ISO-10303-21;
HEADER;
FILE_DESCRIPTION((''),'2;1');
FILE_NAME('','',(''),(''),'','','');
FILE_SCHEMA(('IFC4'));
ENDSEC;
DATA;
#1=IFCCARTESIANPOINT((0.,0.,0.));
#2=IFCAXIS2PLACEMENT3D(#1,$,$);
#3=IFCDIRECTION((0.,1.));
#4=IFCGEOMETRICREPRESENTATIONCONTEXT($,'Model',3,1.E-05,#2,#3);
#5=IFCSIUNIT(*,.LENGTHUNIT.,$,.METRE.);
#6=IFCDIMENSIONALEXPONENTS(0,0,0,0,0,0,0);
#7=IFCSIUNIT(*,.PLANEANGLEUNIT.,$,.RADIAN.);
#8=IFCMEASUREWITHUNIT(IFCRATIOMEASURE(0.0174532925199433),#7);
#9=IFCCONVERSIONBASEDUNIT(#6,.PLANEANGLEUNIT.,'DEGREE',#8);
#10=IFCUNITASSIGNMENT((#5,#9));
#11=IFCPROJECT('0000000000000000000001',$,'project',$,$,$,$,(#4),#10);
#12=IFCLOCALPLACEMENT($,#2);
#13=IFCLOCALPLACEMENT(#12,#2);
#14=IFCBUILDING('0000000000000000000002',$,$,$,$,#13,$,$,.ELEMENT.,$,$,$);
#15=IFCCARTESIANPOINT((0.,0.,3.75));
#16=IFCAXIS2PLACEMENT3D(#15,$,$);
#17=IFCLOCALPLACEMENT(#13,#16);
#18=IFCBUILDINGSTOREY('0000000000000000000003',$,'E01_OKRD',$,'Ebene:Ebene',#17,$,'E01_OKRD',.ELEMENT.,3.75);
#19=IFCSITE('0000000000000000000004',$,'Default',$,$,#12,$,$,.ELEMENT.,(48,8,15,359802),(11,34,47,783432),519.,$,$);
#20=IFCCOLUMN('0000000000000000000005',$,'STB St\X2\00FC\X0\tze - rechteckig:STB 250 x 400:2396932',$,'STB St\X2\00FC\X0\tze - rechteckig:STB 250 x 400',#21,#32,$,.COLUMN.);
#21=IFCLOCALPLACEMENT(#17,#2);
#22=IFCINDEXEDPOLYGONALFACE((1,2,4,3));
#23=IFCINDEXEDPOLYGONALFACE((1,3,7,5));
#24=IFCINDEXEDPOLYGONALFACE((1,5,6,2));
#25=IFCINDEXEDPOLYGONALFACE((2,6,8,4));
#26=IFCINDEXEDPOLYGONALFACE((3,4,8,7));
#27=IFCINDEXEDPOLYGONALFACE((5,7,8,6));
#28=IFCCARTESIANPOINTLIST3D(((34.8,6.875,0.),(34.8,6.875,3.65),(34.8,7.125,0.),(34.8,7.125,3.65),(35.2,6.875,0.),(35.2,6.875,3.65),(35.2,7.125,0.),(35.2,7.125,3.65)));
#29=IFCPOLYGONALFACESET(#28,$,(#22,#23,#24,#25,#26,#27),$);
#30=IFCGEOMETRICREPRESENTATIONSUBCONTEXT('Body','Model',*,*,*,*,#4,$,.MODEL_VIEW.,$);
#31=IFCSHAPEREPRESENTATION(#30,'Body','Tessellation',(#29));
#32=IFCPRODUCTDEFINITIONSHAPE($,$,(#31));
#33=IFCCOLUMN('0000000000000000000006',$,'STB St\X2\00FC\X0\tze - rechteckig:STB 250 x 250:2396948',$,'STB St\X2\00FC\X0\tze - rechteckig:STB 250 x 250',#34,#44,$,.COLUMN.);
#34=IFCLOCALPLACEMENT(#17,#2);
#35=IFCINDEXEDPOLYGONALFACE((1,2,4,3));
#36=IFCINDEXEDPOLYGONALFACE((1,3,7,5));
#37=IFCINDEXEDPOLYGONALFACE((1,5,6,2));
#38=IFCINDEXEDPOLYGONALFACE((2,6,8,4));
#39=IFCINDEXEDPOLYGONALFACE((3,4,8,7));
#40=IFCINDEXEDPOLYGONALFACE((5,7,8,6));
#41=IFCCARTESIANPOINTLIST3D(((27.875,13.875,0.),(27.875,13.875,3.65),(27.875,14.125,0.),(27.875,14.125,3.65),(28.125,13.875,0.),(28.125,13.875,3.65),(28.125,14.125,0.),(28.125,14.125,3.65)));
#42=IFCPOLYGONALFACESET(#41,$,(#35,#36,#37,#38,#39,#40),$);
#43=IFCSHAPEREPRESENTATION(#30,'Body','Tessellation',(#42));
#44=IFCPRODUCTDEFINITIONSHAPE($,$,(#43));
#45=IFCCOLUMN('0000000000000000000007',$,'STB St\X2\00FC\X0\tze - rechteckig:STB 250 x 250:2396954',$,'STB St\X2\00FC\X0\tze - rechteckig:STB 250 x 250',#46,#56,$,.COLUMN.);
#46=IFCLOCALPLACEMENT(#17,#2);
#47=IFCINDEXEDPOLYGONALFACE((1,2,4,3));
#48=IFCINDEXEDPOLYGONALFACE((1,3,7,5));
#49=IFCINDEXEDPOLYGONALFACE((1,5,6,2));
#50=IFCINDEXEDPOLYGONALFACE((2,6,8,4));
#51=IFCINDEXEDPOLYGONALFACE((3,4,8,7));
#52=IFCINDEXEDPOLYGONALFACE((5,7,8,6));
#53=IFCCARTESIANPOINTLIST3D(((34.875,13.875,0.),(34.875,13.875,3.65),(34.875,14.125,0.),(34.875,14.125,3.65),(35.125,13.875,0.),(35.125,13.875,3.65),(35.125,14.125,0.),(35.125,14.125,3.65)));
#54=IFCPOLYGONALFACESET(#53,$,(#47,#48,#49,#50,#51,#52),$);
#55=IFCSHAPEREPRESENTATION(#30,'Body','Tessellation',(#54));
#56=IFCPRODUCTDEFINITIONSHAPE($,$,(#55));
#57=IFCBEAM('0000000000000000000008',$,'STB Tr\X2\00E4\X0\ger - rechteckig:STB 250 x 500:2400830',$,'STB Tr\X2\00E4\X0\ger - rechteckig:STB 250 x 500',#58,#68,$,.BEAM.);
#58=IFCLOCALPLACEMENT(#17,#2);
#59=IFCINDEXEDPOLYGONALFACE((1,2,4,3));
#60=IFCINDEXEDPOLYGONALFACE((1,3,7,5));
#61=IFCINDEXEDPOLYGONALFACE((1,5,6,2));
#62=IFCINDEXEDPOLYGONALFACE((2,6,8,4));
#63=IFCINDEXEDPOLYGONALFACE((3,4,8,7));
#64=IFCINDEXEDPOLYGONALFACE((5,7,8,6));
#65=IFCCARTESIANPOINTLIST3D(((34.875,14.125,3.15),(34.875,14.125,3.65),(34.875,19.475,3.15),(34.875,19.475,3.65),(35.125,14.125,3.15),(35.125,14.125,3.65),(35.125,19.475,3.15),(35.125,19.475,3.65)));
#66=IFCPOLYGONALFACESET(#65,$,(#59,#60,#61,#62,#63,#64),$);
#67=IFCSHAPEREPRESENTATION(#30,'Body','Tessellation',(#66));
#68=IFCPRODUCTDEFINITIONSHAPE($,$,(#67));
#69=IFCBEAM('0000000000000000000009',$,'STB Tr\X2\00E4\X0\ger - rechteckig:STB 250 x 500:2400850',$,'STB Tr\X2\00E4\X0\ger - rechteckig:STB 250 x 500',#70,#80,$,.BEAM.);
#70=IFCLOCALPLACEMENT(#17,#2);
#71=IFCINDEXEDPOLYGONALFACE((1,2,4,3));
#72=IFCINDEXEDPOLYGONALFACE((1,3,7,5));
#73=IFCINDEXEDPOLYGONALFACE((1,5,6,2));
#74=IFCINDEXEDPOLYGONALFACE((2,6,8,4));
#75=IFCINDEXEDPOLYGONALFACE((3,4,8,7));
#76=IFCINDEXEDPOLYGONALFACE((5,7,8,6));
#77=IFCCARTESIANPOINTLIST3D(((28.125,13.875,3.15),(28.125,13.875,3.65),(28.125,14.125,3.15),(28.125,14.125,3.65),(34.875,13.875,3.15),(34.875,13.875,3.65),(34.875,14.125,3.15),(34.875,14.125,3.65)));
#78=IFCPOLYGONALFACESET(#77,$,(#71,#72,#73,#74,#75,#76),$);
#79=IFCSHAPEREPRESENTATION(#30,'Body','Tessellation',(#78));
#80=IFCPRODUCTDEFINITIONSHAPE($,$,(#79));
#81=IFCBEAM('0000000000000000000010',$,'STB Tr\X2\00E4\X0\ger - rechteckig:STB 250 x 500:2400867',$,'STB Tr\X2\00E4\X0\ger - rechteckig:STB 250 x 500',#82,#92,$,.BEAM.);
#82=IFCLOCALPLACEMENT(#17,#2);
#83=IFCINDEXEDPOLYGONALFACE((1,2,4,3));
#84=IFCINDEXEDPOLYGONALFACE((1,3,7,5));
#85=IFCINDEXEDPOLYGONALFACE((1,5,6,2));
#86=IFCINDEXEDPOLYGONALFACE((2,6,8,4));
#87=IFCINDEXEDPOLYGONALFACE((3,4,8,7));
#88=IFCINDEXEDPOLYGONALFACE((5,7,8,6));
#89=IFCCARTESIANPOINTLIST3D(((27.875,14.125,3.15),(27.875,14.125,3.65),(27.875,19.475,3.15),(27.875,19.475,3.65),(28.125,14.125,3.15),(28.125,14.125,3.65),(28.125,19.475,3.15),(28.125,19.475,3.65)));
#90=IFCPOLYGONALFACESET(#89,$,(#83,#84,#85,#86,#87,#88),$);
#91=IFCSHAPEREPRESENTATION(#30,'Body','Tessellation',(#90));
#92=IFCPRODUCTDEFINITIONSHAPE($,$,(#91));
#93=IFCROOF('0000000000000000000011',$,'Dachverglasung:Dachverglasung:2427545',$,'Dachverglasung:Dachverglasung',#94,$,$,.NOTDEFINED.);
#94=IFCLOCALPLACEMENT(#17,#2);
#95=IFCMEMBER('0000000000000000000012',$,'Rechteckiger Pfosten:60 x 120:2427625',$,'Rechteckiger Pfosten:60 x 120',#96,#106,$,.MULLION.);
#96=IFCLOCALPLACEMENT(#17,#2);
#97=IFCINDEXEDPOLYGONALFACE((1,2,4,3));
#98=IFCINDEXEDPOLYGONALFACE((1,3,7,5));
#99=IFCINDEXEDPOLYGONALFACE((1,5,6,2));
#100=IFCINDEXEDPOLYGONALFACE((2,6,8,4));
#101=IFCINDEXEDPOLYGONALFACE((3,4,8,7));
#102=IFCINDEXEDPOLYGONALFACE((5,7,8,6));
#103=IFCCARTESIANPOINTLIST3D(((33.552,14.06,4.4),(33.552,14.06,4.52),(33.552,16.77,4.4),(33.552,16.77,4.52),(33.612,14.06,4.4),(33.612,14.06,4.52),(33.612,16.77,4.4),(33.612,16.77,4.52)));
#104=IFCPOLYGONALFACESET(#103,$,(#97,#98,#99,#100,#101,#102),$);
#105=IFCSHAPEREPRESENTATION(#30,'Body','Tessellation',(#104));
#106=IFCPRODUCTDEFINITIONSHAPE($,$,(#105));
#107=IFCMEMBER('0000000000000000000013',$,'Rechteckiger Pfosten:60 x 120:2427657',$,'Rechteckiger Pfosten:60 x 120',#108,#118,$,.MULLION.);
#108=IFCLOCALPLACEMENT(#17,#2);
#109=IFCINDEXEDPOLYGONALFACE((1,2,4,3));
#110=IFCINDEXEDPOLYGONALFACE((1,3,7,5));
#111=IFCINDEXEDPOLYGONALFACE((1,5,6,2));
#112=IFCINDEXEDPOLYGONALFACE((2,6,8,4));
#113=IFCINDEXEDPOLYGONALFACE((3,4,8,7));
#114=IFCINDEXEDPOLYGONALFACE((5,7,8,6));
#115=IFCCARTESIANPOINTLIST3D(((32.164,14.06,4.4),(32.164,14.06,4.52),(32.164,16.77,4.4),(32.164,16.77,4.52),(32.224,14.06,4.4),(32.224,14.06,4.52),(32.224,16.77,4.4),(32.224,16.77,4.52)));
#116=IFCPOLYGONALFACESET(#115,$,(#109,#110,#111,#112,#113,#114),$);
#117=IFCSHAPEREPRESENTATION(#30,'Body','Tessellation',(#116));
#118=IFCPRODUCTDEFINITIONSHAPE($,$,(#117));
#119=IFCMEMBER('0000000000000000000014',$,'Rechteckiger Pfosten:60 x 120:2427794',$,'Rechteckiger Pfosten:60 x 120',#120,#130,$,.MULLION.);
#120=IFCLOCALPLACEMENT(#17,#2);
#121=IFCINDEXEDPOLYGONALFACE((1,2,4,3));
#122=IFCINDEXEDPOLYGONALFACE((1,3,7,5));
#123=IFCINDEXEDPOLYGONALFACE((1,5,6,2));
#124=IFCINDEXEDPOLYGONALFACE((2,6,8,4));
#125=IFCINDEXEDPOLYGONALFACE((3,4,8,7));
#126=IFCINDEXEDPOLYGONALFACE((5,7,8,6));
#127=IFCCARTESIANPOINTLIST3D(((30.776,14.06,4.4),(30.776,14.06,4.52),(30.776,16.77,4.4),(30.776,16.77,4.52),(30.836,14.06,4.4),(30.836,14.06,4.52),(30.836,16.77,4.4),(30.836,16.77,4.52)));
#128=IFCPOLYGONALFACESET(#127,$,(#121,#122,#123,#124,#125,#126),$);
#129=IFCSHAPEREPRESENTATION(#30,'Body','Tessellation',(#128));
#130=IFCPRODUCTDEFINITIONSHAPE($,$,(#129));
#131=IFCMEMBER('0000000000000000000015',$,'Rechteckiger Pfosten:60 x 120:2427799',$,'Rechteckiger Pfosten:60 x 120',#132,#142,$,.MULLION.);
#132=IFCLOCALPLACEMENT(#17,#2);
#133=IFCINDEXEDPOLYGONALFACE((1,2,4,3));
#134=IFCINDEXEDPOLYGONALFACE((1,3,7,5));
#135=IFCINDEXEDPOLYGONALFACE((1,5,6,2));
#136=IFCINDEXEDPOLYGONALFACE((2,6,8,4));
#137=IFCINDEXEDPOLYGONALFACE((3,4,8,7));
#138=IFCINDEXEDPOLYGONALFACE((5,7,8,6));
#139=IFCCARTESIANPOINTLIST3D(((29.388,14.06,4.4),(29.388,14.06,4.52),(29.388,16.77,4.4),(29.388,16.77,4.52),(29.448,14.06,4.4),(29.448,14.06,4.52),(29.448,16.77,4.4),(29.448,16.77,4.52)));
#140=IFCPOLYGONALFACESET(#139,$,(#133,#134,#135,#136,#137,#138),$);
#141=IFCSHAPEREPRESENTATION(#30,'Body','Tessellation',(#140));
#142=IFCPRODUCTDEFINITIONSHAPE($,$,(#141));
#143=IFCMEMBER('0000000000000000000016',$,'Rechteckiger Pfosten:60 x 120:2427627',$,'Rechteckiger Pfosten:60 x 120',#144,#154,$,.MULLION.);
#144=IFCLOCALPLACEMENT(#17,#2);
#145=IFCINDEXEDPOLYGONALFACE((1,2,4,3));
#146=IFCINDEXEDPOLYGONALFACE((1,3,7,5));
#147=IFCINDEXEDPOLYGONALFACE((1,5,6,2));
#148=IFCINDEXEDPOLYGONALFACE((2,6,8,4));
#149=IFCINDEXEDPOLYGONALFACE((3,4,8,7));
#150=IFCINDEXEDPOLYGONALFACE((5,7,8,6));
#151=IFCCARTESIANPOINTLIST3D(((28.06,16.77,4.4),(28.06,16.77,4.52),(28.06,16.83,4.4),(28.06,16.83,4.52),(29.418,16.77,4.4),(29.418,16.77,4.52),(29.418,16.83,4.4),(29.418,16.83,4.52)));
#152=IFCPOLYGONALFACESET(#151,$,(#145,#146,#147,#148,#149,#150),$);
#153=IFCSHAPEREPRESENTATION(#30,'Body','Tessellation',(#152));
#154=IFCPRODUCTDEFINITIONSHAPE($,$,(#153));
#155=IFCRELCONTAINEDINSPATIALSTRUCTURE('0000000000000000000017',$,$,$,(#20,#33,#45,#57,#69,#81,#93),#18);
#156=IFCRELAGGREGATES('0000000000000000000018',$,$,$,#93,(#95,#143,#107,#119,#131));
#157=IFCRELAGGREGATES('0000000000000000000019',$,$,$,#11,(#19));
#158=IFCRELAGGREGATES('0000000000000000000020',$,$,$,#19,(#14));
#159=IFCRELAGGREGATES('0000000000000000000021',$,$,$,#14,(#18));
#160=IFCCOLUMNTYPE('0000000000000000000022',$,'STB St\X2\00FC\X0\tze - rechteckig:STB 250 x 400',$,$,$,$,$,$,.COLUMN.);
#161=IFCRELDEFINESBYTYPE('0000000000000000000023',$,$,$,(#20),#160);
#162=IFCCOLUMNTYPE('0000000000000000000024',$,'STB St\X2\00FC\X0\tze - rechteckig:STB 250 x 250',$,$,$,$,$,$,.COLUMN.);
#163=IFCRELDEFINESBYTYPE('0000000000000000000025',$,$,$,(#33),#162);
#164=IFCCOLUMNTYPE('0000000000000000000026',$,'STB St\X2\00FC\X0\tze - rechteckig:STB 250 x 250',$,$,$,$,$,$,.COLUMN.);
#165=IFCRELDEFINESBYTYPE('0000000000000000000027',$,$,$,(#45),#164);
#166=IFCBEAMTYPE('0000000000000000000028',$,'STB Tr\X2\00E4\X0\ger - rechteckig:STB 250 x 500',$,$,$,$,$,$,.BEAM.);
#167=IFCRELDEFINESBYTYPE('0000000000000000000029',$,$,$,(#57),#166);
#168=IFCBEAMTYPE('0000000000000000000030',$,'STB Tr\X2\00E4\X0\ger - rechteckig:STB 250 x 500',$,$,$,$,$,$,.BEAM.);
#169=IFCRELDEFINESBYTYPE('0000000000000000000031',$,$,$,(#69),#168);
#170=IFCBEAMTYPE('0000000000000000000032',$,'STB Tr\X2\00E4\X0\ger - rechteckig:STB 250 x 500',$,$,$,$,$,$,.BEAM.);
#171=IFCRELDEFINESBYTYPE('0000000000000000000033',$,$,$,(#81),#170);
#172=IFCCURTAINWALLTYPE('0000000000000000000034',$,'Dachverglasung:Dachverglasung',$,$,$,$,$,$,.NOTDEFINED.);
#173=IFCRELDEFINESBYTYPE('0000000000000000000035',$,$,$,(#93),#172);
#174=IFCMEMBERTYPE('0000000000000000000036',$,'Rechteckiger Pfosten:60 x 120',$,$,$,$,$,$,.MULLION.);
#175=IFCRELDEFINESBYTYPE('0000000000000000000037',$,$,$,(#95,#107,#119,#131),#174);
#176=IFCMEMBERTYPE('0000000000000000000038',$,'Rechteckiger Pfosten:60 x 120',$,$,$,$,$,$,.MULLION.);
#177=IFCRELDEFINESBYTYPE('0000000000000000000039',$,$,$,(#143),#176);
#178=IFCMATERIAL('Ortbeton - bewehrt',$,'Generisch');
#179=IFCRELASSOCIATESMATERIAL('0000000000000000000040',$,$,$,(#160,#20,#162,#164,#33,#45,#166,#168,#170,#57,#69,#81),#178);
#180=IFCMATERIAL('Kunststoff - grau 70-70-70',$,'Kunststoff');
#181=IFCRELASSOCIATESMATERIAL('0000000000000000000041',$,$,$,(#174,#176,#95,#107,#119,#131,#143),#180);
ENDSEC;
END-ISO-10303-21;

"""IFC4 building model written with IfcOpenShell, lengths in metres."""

from ifc_helpers import new_model, entity, si_unit, converted_unit, direction, frame, frame_2d, origin, origin_2d_with_axis, place, context, subcontext, project, spatial, rectangle, extrude, source, transform, mapped, material, material_profile, profile_set, profile_usage, type_object, type_shapes, element, aggregate, save


model = new_model("IFC4")

# Units and contexts
model_context = context("Model", 3, precision=1e-05, world=origin(), true_north=direction((0.0, 1.0)))
body_context = subcontext(model_context, "Body", "Model", "MODEL_VIEW")
ifc_project = project(units=[si_unit("LENGTHUNIT", "METRE"), converted_unit("PLANEANGLEUNIT", "DEGREE", entity("IfcRatioMeasure", 0.0174532925199433), si_unit("PLANEANGLEUNIT", "RADIAN"), dimensions=[0, 0, 0, 0, 0, 0, 0])], contexts=[model_context])

# Site, building, storey
site_placement = place(None, frame((0.0, 0.0, 0.0)))
site = spatial("IfcSite", under=ifc_project, at=site_placement, Name="Default", CompositionType="ELEMENT", RefLatitude=(48, 8, 15, 359802), RefLongitude=(11, 34, 47, 783432), RefElevation=519.0)
building_placement = place(site_placement, origin())
building = spatial("IfcBuilding", under=site, at=building_placement, CompositionType="ELEMENT")
storey_placement = place(building_placement, frame((0.0, 0.0, 3.75)))
storey = spatial("IfcBuildingStorey", under=building, at=storey_placement, Name="E01_OKRD", ObjectType="Ebene:Ebene", LongName="E01_OKRD", CompositionType="ELEMENT", Elevation=3.75)

# Columns
ifc_material_1 = material(Name="Ortbeton - bewehrt", Category="Generisch")
ifc_material_profile_1 = material_profile(ifc_material_1, rectangle(XDim=0.4, YDim=0.25, at=frame_2d((0.0, 0.0), x_axis=(1.0, 0.0))), Name="STB 250 x 400")
ifc_profile_set_1 = profile_set([ifc_material_profile_1], Name="STB 250 x 400")
ifc_profile_usage_1 = profile_usage(ifc_profile_set_1)
column_type_1 = type_object("IfcColumnType", Name="STB Stütze - rechteckig:STB 250 x 400", PredefinedType="COLUMN", material=ifc_profile_set_1)
shared_shape_1 = source(origin(), body_context, "Body", "SweptSolid", [
    extrude(rectangle(XDim=0.4, YDim=0.25, at=frame_2d((0.0, 0.0), x_axis=(1.0, 0.0))), frame((0.2, 0.125, 0.0), z_axis=(0.0, 0.0, 1.0), x_axis=(-1.0, 0.0, 0.0)), (0.0, 0.0, 1.0), 3.65),
])
type_shapes(column_type_1, [shared_shape_1])
column_1_placement = place(storey_placement, frame((34.8, 6.875, 0.0)))
element("IfcColumn", 1, at=column_1_placement, inside=storey, type_object=column_type_1, material=ifc_profile_usage_1, Name="STB Stütze - rechteckig:STB 250 x 400:2396932", ObjectType="STB Stütze - rechteckig:STB 250 x 400", PredefinedType="COLUMN", context=body_context, shape_type="MappedRepresentation", body=[
    mapped(shared_shape_1, transform((0.0, 0.0, 0.0), scale=1.0)),
])
ifc_material_profile_2 = material_profile(ifc_material_1, rectangle(XDim=0.25, YDim=0.25, at=origin_2d_with_axis()), Name="STB 250 x 250")
ifc_profile_set_2 = profile_set([ifc_material_profile_2], Name="STB 250 x 250")
ifc_profile_usage_2 = profile_usage(ifc_profile_set_2)
column_type_2 = type_object("IfcColumnType", Name="STB Stütze - rechteckig:STB 250 x 250", PredefinedType="COLUMN", material=ifc_profile_set_2)
shared_shape_2 = source(origin(), body_context, "Body", "SweptSolid", [
    extrude(rectangle(XDim=0.25, YDim=0.25, at=frame_2d((0.0, 0.0), x_axis=(1.0, 0.0))), frame((0.125, 0.125, 0.0), z_axis=(0.0, 0.0, 1.0), x_axis=(-1.0, 0.0, 0.0)), (0.0, 0.0, 1.0), 3.65),
])
type_shapes(column_type_2, [shared_shape_2])
column_2_placement = place(storey_placement, frame((27.875, 13.875, 0.0)))
element("IfcColumn", 2, at=column_2_placement, inside=storey, type_object=column_type_2, material=ifc_profile_usage_2, Name="STB Stütze - rechteckig:STB 250 x 250:2396948", ObjectType="STB Stütze - rechteckig:STB 250 x 250", PredefinedType="COLUMN", context=body_context, shape_type="MappedRepresentation", body=[
    mapped(shared_shape_2, transform((0.0, 0.0, 0.0), scale=1.0)),
])
ifc_profile_usage_3 = profile_usage(ifc_profile_set_2)
column_type_3 = type_object("IfcColumnType", Name="STB Stütze - rechteckig:STB 250 x 250", PredefinedType="COLUMN", material=ifc_profile_set_2)
shared_shape_3 = source(origin(), body_context, "Body", "SweptSolid", [
    extrude(rectangle(XDim=0.25, YDim=0.25, at=frame_2d((0.0, 0.0), x_axis=(1.0, 0.0))), frame((0.125, 0.125, 0.0), z_axis=(0.0, 0.0, 1.0), x_axis=(-1.0, 0.0, 0.0)), (0.0, 0.0, 1.0), 3.65),
])
type_shapes(column_type_3, [shared_shape_3])
column_3_placement = place(storey_placement, frame((34.875, 13.875, 0.0)))
element("IfcColumn", 3, at=column_3_placement, inside=storey, type_object=column_type_3, material=ifc_profile_usage_3, Name="STB Stütze - rechteckig:STB 250 x 250:2396954", ObjectType="STB Stütze - rechteckig:STB 250 x 250", PredefinedType="COLUMN", context=body_context, shape_type="MappedRepresentation", body=[
    mapped(shared_shape_3, transform((0.0, 0.0, 0.0), scale=1.0)),
])

# Beams
ifc_material_profile_3 = material_profile(ifc_material_1, rectangle(XDim=0.5, YDim=0.25, at=frame_2d((0.0, 0.0), x_axis=(1.0, 0.0))), Name="STB 250 x 500")
ifc_profile_set_3 = profile_set([ifc_material_profile_3], Name="STB 250 x 500")
ifc_profile_usage_4 = profile_usage(ifc_profile_set_3, cardinal=8)
beam_type_1 = type_object("IfcBeamType", Name="STB Träger - rechteckig:STB 250 x 500", PredefinedType="BEAM", material=ifc_profile_set_3)
shared_shape_4 = source(origin(), body_context, "Body", "SweptSolid", [
    extrude(rectangle(XDim=0.5, YDim=5.35, at=frame_2d((0.0, 0.0), x_axis=(0.0, 1.0))), frame((0.0, 2.675, 0.25), z_axis=(1.0, 0.0, 0.0), x_axis=(0.0, -1.0, 0.0)), (0.0, 0.0, 1.0), 0.25),
])
type_shapes(beam_type_1, [shared_shape_4])
beam_1_placement = place(storey_placement, frame((34.875, 14.125, 3.15)))
element("IfcBeam", 4, at=beam_1_placement, inside=storey, type_object=beam_type_1, material=ifc_profile_usage_4, Name="STB Träger - rechteckig:STB 250 x 500:2400830", ObjectType="STB Träger - rechteckig:STB 250 x 500", PredefinedType="BEAM", context=body_context, shape_type="MappedRepresentation", body=[
    mapped(shared_shape_4, transform((0.0, 0.0, 0.0), scale=1.0)),
])
ifc_profile_usage_5 = profile_usage(ifc_profile_set_3, cardinal=8)
beam_type_2 = type_object("IfcBeamType", Name="STB Träger - rechteckig:STB 250 x 500", PredefinedType="BEAM", material=ifc_profile_set_3)
shared_shape_5 = source(origin(), body_context, "Body", "SweptSolid", [
    extrude(rectangle(XDim=0.5, YDim=0.25, at=frame_2d((0.0, 0.0), x_axis=(1.0, 0.0))), frame((0.0, 0.125, 0.25), z_axis=(1.0, 0.0, 0.0), x_axis=(0.0, 0.0, -1.0)), (0.0, 0.0, 1.0), 6.75),
])
type_shapes(beam_type_2, [shared_shape_5])
beam_2_placement = place(storey_placement, frame((28.125, 13.875, 3.15)))
element("IfcBeam", 5, at=beam_2_placement, inside=storey, type_object=beam_type_2, material=ifc_profile_usage_5, Name="STB Träger - rechteckig:STB 250 x 500:2400850", ObjectType="STB Träger - rechteckig:STB 250 x 500", PredefinedType="BEAM", context=body_context, shape_type="MappedRepresentation", body=[
    mapped(shared_shape_5, transform((0.0, 0.0, 0.0), scale=1.0)),
])
ifc_profile_usage_6 = profile_usage(ifc_profile_set_3, cardinal=8)
beam_type_3 = type_object("IfcBeamType", Name="STB Träger - rechteckig:STB 250 x 500", PredefinedType="BEAM", material=ifc_profile_set_3)
shared_shape_6 = source(origin(), body_context, "Body", "SweptSolid", [
    extrude(rectangle(XDim=0.5, YDim=5.35, at=frame_2d((0.0, 0.0), x_axis=(0.0, 1.0))), frame((0.0, 2.675, 0.25), z_axis=(1.0, 0.0, 0.0), x_axis=(0.0, 1.0, 0.0)), (0.0, 0.0, 1.0), 0.25),
])
type_shapes(beam_type_3, [shared_shape_6])
beam_3_placement = place(storey_placement, frame((27.875, 14.125, 3.15)))
element("IfcBeam", 6, at=beam_3_placement, inside=storey, type_object=beam_type_3, material=ifc_profile_usage_6, Name="STB Träger - rechteckig:STB 250 x 500:2400867", ObjectType="STB Träger - rechteckig:STB 250 x 500", PredefinedType="BEAM", context=body_context, shape_type="MappedRepresentation", body=[
    mapped(shared_shape_6, transform((0.0, 0.0, 0.0), scale=1.0)),
])

# Roof, members
curtain_wall_type = type_object("IfcCurtainWallType", Name="Dachverglasung:Dachverglasung", PredefinedType="NOTDEFINED")
roof_placement = place(storey_placement, frame((0.0, 0.0, -3.75)))
roof = element("IfcRoof", 7, at=roof_placement, inside=storey, type_object=curtain_wall_type, Name="Dachverglasung:Dachverglasung:2427545", ObjectType="Dachverglasung:Dachverglasung", PredefinedType="NOTDEFINED")
ifc_material_2 = material(Name="Kunststoff - grau 70-70-70", Category="Kunststoff")
ifc_material_profile_4 = material_profile(ifc_material_2, rectangle(XDim=0.06, YDim=0.12, at=frame_2d((0.0, 0.0), x_axis=(1.0, 0.0))), Name="60 x 120")
ifc_profile_set_4 = profile_set([ifc_material_profile_4], Name="60 x 120")
ifc_profile_usage_7 = profile_usage(ifc_profile_set_4)
member_type_1 = type_object("IfcMemberType", Name="Rechteckiger Pfosten:60 x 120", PredefinedType="MULLION", material=ifc_profile_set_4)
shared_shape_7 = source(origin(), body_context, "Body", "SweptSolid", [
    extrude(rectangle(XDim=0.06, YDim=0.12, at=frame_2d((0.0, 0.0), x_axis=(1.0, 0.0))), frame((0.0, 0.0, -2.71), z_axis=(0.0, 0.0, 1.0), x_axis=(-1.0, 0.0, 0.0)), (0.0, 0.0, 1.0), 2.71),
])
type_shapes(member_type_1, [shared_shape_7])
member_1_placement = place(storey_placement, frame((33.582, 14.06, 4.46), z_axis=(0.0, -1.0, 0.0), x_axis=(-1.0, 0.0, 0.0)))
member_1 = element("IfcMember", 8, at=member_1_placement, type_object=member_type_1, material=ifc_profile_usage_7, Name="Rechteckiger Pfosten:60 x 120:2427625", ObjectType="Rechteckiger Pfosten:60 x 120", PredefinedType="MULLION", context=body_context, shape_type="MappedRepresentation", body=[
    mapped(shared_shape_7, transform((0.0, 0.0, 0.0), scale=1.0)),
])
ifc_profile_usage_8 = profile_usage(ifc_profile_set_4)
member_2_placement = place(storey_placement, frame((32.194, 14.06, 4.46), z_axis=(0.0, -1.0, 0.0), x_axis=(-1.0, 0.0, 0.0)))
member_2 = element("IfcMember", 9, at=member_2_placement, type_object=member_type_1, material=ifc_profile_usage_8, Name="Rechteckiger Pfosten:60 x 120:2427657", ObjectType="Rechteckiger Pfosten:60 x 120", PredefinedType="MULLION", context=body_context, shape_type="MappedRepresentation", body=[
    mapped(shared_shape_7, transform((0.0, 0.0, 0.0), scale=1.0)),
])
ifc_profile_usage_9 = profile_usage(ifc_profile_set_4)
member_3_placement = place(storey_placement, frame((30.806, 14.06, 4.46), z_axis=(0.0, -1.0, 0.0), x_axis=(-1.0, 0.0, 0.0)))
member_3 = element("IfcMember", 10, at=member_3_placement, type_object=member_type_1, material=ifc_profile_usage_9, Name="Rechteckiger Pfosten:60 x 120:2427794", ObjectType="Rechteckiger Pfosten:60 x 120", PredefinedType="MULLION", context=body_context, shape_type="MappedRepresentation", body=[
    mapped(shared_shape_7, transform((0.0, 0.0, 0.0), scale=1.0)),
])
ifc_profile_usage_10 = profile_usage(ifc_profile_set_4)
member_4_placement = place(storey_placement, frame((29.418, 14.06, 4.46), z_axis=(0.0, -1.0, 0.0), x_axis=(-1.0, 0.0, 0.0)))
member_4 = element("IfcMember", 11, at=member_4_placement, type_object=member_type_1, material=ifc_profile_usage_10, Name="Rechteckiger Pfosten:60 x 120:2427799", ObjectType="Rechteckiger Pfosten:60 x 120", PredefinedType="MULLION", context=body_context, shape_type="MappedRepresentation", body=[
    mapped(shared_shape_7, transform((0.0, 0.0, 0.0), scale=1.0)),
])
ifc_profile_usage_11 = profile_usage(ifc_profile_set_4)
member_type_2 = type_object("IfcMemberType", Name="Rechteckiger Pfosten:60 x 120", PredefinedType="MULLION", material=ifc_profile_set_4)
shared_shape_8 = source(origin(), body_context, "Body", "SweptSolid", [
    extrude(rectangle(XDim=0.06, YDim=0.12, at=frame_2d((0.0, 0.0), x_axis=(1.0, 0.0))), frame((0.0, 0.0, -1.358), z_axis=(0.0, 0.0, 1.0), x_axis=(-1.0, 0.0, 0.0)), (0.0, 0.0, 1.0), 1.358),
])
type_shapes(member_type_2, [shared_shape_8])
member_5_placement = place(storey_placement, frame((28.06, 16.8, 4.46), z_axis=(-1.0, 0.0, 0.0), x_axis=(0.0, 1.0, 0.0)))
member_5 = element("IfcMember", 12, at=member_5_placement, type_object=member_type_2, material=ifc_profile_usage_11, Name="Rechteckiger Pfosten:60 x 120:2427627", ObjectType="Rechteckiger Pfosten:60 x 120", PredefinedType="MULLION", context=body_context, shape_type="MappedRepresentation", body=[
    mapped(shared_shape_8, transform((0.0, 0.0, 0.0), scale=1.0)),
])
aggregate(roof, [member_1, member_5, member_2, member_3, member_4])

save(model, "model.ifc")
